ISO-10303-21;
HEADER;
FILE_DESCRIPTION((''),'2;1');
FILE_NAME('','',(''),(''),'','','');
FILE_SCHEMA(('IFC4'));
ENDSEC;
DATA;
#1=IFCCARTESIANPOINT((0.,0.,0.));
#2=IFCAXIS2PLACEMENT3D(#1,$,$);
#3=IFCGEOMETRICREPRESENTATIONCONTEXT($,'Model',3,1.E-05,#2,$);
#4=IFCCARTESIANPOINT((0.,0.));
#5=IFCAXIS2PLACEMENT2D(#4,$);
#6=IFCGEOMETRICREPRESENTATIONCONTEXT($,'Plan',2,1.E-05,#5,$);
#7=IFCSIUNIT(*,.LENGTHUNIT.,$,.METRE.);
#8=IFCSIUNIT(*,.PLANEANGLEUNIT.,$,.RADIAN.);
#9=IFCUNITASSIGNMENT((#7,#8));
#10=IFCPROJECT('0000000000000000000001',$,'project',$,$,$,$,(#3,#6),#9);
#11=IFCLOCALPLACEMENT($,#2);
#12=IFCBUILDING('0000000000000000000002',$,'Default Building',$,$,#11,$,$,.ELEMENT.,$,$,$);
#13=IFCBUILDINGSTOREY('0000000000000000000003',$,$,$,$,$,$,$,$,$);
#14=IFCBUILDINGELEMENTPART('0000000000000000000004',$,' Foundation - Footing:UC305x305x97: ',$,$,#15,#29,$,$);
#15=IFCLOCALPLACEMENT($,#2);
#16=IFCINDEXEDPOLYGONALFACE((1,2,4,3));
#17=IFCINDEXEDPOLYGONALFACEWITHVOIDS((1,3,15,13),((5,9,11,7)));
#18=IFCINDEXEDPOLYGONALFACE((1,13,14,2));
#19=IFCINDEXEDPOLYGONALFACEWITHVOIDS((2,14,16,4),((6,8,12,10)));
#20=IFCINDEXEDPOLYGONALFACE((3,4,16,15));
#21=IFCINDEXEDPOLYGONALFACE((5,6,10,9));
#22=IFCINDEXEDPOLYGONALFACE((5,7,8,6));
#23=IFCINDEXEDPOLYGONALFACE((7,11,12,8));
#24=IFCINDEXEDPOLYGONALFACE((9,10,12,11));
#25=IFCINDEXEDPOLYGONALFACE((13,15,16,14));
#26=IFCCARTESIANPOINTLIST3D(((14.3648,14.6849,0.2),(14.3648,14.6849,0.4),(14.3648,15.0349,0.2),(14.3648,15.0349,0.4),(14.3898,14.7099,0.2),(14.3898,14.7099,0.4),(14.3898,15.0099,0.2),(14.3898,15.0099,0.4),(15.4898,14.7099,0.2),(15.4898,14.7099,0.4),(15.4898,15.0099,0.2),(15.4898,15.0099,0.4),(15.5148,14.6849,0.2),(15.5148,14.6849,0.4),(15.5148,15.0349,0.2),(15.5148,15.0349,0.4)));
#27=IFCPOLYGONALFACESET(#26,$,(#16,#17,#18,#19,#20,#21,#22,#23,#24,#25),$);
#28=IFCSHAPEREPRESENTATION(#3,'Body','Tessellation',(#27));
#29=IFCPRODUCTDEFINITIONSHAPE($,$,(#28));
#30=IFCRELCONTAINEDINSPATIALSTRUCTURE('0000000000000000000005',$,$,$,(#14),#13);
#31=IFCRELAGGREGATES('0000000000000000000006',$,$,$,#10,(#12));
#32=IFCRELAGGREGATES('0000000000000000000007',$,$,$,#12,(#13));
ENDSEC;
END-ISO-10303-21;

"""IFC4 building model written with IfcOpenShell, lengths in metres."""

from ifc_helpers import new_model, si_unit, origin, origin_2d, place, context, project, spatial, polyline, outline, extrude, element, save


model = new_model("IFC4")

# Units and contexts
model_context = context("Model", 3, precision=1e-05, world=origin())
plan_context = context("Plan", 2, precision=1e-05, world=origin_2d())
ifc_project = project(units=[si_unit("LENGTHUNIT", "METRE"), si_unit("PLANEANGLEUNIT", "RADIAN")], contexts=[model_context, plan_context])

# Building, storey
building_placement = place(None, origin())
building = spatial("IfcBuilding", under=ifc_project, at=building_placement, Name="Default Building", CompositionType="ELEMENT")
storey = spatial("IfcBuildingStorey", under=building)

# Building element part, opening
building_element_part_1 = element("IfcBuildingElementPart", 1, inside=storey, Name=" Foundation - Footing:UC305x305x97: ", context=model_context, shape_type="SweptSolid", body=[
    extrude(outline(polyline([(14.3648, 15.0349, 0.2), (15.5148, 15.0349, 0.2), (15.5148, 14.6849, 0.2), (14.3648, 14.6849, 0.2), (14.3648, 15.0349, 0.2)])), None, (0.0, 0.0, 1.0), 0.2),
])
element("IfcOpeningElement", 2, inside=storey, cuts=building_element_part_1, context=model_context, shape_type="SweptSolid", body=[
    extrude(outline(polyline([(14.3898, 15.0099, 0.2), (15.4898, 15.0099, 0.2), (15.4898, 14.7099, 0.2), (14.3898, 14.7099, 0.2), (14.3898, 15.0099, 0.2)])), None, (0.0, 0.0, 1.0), 0.2),
])

save(model, "model.ifc")
